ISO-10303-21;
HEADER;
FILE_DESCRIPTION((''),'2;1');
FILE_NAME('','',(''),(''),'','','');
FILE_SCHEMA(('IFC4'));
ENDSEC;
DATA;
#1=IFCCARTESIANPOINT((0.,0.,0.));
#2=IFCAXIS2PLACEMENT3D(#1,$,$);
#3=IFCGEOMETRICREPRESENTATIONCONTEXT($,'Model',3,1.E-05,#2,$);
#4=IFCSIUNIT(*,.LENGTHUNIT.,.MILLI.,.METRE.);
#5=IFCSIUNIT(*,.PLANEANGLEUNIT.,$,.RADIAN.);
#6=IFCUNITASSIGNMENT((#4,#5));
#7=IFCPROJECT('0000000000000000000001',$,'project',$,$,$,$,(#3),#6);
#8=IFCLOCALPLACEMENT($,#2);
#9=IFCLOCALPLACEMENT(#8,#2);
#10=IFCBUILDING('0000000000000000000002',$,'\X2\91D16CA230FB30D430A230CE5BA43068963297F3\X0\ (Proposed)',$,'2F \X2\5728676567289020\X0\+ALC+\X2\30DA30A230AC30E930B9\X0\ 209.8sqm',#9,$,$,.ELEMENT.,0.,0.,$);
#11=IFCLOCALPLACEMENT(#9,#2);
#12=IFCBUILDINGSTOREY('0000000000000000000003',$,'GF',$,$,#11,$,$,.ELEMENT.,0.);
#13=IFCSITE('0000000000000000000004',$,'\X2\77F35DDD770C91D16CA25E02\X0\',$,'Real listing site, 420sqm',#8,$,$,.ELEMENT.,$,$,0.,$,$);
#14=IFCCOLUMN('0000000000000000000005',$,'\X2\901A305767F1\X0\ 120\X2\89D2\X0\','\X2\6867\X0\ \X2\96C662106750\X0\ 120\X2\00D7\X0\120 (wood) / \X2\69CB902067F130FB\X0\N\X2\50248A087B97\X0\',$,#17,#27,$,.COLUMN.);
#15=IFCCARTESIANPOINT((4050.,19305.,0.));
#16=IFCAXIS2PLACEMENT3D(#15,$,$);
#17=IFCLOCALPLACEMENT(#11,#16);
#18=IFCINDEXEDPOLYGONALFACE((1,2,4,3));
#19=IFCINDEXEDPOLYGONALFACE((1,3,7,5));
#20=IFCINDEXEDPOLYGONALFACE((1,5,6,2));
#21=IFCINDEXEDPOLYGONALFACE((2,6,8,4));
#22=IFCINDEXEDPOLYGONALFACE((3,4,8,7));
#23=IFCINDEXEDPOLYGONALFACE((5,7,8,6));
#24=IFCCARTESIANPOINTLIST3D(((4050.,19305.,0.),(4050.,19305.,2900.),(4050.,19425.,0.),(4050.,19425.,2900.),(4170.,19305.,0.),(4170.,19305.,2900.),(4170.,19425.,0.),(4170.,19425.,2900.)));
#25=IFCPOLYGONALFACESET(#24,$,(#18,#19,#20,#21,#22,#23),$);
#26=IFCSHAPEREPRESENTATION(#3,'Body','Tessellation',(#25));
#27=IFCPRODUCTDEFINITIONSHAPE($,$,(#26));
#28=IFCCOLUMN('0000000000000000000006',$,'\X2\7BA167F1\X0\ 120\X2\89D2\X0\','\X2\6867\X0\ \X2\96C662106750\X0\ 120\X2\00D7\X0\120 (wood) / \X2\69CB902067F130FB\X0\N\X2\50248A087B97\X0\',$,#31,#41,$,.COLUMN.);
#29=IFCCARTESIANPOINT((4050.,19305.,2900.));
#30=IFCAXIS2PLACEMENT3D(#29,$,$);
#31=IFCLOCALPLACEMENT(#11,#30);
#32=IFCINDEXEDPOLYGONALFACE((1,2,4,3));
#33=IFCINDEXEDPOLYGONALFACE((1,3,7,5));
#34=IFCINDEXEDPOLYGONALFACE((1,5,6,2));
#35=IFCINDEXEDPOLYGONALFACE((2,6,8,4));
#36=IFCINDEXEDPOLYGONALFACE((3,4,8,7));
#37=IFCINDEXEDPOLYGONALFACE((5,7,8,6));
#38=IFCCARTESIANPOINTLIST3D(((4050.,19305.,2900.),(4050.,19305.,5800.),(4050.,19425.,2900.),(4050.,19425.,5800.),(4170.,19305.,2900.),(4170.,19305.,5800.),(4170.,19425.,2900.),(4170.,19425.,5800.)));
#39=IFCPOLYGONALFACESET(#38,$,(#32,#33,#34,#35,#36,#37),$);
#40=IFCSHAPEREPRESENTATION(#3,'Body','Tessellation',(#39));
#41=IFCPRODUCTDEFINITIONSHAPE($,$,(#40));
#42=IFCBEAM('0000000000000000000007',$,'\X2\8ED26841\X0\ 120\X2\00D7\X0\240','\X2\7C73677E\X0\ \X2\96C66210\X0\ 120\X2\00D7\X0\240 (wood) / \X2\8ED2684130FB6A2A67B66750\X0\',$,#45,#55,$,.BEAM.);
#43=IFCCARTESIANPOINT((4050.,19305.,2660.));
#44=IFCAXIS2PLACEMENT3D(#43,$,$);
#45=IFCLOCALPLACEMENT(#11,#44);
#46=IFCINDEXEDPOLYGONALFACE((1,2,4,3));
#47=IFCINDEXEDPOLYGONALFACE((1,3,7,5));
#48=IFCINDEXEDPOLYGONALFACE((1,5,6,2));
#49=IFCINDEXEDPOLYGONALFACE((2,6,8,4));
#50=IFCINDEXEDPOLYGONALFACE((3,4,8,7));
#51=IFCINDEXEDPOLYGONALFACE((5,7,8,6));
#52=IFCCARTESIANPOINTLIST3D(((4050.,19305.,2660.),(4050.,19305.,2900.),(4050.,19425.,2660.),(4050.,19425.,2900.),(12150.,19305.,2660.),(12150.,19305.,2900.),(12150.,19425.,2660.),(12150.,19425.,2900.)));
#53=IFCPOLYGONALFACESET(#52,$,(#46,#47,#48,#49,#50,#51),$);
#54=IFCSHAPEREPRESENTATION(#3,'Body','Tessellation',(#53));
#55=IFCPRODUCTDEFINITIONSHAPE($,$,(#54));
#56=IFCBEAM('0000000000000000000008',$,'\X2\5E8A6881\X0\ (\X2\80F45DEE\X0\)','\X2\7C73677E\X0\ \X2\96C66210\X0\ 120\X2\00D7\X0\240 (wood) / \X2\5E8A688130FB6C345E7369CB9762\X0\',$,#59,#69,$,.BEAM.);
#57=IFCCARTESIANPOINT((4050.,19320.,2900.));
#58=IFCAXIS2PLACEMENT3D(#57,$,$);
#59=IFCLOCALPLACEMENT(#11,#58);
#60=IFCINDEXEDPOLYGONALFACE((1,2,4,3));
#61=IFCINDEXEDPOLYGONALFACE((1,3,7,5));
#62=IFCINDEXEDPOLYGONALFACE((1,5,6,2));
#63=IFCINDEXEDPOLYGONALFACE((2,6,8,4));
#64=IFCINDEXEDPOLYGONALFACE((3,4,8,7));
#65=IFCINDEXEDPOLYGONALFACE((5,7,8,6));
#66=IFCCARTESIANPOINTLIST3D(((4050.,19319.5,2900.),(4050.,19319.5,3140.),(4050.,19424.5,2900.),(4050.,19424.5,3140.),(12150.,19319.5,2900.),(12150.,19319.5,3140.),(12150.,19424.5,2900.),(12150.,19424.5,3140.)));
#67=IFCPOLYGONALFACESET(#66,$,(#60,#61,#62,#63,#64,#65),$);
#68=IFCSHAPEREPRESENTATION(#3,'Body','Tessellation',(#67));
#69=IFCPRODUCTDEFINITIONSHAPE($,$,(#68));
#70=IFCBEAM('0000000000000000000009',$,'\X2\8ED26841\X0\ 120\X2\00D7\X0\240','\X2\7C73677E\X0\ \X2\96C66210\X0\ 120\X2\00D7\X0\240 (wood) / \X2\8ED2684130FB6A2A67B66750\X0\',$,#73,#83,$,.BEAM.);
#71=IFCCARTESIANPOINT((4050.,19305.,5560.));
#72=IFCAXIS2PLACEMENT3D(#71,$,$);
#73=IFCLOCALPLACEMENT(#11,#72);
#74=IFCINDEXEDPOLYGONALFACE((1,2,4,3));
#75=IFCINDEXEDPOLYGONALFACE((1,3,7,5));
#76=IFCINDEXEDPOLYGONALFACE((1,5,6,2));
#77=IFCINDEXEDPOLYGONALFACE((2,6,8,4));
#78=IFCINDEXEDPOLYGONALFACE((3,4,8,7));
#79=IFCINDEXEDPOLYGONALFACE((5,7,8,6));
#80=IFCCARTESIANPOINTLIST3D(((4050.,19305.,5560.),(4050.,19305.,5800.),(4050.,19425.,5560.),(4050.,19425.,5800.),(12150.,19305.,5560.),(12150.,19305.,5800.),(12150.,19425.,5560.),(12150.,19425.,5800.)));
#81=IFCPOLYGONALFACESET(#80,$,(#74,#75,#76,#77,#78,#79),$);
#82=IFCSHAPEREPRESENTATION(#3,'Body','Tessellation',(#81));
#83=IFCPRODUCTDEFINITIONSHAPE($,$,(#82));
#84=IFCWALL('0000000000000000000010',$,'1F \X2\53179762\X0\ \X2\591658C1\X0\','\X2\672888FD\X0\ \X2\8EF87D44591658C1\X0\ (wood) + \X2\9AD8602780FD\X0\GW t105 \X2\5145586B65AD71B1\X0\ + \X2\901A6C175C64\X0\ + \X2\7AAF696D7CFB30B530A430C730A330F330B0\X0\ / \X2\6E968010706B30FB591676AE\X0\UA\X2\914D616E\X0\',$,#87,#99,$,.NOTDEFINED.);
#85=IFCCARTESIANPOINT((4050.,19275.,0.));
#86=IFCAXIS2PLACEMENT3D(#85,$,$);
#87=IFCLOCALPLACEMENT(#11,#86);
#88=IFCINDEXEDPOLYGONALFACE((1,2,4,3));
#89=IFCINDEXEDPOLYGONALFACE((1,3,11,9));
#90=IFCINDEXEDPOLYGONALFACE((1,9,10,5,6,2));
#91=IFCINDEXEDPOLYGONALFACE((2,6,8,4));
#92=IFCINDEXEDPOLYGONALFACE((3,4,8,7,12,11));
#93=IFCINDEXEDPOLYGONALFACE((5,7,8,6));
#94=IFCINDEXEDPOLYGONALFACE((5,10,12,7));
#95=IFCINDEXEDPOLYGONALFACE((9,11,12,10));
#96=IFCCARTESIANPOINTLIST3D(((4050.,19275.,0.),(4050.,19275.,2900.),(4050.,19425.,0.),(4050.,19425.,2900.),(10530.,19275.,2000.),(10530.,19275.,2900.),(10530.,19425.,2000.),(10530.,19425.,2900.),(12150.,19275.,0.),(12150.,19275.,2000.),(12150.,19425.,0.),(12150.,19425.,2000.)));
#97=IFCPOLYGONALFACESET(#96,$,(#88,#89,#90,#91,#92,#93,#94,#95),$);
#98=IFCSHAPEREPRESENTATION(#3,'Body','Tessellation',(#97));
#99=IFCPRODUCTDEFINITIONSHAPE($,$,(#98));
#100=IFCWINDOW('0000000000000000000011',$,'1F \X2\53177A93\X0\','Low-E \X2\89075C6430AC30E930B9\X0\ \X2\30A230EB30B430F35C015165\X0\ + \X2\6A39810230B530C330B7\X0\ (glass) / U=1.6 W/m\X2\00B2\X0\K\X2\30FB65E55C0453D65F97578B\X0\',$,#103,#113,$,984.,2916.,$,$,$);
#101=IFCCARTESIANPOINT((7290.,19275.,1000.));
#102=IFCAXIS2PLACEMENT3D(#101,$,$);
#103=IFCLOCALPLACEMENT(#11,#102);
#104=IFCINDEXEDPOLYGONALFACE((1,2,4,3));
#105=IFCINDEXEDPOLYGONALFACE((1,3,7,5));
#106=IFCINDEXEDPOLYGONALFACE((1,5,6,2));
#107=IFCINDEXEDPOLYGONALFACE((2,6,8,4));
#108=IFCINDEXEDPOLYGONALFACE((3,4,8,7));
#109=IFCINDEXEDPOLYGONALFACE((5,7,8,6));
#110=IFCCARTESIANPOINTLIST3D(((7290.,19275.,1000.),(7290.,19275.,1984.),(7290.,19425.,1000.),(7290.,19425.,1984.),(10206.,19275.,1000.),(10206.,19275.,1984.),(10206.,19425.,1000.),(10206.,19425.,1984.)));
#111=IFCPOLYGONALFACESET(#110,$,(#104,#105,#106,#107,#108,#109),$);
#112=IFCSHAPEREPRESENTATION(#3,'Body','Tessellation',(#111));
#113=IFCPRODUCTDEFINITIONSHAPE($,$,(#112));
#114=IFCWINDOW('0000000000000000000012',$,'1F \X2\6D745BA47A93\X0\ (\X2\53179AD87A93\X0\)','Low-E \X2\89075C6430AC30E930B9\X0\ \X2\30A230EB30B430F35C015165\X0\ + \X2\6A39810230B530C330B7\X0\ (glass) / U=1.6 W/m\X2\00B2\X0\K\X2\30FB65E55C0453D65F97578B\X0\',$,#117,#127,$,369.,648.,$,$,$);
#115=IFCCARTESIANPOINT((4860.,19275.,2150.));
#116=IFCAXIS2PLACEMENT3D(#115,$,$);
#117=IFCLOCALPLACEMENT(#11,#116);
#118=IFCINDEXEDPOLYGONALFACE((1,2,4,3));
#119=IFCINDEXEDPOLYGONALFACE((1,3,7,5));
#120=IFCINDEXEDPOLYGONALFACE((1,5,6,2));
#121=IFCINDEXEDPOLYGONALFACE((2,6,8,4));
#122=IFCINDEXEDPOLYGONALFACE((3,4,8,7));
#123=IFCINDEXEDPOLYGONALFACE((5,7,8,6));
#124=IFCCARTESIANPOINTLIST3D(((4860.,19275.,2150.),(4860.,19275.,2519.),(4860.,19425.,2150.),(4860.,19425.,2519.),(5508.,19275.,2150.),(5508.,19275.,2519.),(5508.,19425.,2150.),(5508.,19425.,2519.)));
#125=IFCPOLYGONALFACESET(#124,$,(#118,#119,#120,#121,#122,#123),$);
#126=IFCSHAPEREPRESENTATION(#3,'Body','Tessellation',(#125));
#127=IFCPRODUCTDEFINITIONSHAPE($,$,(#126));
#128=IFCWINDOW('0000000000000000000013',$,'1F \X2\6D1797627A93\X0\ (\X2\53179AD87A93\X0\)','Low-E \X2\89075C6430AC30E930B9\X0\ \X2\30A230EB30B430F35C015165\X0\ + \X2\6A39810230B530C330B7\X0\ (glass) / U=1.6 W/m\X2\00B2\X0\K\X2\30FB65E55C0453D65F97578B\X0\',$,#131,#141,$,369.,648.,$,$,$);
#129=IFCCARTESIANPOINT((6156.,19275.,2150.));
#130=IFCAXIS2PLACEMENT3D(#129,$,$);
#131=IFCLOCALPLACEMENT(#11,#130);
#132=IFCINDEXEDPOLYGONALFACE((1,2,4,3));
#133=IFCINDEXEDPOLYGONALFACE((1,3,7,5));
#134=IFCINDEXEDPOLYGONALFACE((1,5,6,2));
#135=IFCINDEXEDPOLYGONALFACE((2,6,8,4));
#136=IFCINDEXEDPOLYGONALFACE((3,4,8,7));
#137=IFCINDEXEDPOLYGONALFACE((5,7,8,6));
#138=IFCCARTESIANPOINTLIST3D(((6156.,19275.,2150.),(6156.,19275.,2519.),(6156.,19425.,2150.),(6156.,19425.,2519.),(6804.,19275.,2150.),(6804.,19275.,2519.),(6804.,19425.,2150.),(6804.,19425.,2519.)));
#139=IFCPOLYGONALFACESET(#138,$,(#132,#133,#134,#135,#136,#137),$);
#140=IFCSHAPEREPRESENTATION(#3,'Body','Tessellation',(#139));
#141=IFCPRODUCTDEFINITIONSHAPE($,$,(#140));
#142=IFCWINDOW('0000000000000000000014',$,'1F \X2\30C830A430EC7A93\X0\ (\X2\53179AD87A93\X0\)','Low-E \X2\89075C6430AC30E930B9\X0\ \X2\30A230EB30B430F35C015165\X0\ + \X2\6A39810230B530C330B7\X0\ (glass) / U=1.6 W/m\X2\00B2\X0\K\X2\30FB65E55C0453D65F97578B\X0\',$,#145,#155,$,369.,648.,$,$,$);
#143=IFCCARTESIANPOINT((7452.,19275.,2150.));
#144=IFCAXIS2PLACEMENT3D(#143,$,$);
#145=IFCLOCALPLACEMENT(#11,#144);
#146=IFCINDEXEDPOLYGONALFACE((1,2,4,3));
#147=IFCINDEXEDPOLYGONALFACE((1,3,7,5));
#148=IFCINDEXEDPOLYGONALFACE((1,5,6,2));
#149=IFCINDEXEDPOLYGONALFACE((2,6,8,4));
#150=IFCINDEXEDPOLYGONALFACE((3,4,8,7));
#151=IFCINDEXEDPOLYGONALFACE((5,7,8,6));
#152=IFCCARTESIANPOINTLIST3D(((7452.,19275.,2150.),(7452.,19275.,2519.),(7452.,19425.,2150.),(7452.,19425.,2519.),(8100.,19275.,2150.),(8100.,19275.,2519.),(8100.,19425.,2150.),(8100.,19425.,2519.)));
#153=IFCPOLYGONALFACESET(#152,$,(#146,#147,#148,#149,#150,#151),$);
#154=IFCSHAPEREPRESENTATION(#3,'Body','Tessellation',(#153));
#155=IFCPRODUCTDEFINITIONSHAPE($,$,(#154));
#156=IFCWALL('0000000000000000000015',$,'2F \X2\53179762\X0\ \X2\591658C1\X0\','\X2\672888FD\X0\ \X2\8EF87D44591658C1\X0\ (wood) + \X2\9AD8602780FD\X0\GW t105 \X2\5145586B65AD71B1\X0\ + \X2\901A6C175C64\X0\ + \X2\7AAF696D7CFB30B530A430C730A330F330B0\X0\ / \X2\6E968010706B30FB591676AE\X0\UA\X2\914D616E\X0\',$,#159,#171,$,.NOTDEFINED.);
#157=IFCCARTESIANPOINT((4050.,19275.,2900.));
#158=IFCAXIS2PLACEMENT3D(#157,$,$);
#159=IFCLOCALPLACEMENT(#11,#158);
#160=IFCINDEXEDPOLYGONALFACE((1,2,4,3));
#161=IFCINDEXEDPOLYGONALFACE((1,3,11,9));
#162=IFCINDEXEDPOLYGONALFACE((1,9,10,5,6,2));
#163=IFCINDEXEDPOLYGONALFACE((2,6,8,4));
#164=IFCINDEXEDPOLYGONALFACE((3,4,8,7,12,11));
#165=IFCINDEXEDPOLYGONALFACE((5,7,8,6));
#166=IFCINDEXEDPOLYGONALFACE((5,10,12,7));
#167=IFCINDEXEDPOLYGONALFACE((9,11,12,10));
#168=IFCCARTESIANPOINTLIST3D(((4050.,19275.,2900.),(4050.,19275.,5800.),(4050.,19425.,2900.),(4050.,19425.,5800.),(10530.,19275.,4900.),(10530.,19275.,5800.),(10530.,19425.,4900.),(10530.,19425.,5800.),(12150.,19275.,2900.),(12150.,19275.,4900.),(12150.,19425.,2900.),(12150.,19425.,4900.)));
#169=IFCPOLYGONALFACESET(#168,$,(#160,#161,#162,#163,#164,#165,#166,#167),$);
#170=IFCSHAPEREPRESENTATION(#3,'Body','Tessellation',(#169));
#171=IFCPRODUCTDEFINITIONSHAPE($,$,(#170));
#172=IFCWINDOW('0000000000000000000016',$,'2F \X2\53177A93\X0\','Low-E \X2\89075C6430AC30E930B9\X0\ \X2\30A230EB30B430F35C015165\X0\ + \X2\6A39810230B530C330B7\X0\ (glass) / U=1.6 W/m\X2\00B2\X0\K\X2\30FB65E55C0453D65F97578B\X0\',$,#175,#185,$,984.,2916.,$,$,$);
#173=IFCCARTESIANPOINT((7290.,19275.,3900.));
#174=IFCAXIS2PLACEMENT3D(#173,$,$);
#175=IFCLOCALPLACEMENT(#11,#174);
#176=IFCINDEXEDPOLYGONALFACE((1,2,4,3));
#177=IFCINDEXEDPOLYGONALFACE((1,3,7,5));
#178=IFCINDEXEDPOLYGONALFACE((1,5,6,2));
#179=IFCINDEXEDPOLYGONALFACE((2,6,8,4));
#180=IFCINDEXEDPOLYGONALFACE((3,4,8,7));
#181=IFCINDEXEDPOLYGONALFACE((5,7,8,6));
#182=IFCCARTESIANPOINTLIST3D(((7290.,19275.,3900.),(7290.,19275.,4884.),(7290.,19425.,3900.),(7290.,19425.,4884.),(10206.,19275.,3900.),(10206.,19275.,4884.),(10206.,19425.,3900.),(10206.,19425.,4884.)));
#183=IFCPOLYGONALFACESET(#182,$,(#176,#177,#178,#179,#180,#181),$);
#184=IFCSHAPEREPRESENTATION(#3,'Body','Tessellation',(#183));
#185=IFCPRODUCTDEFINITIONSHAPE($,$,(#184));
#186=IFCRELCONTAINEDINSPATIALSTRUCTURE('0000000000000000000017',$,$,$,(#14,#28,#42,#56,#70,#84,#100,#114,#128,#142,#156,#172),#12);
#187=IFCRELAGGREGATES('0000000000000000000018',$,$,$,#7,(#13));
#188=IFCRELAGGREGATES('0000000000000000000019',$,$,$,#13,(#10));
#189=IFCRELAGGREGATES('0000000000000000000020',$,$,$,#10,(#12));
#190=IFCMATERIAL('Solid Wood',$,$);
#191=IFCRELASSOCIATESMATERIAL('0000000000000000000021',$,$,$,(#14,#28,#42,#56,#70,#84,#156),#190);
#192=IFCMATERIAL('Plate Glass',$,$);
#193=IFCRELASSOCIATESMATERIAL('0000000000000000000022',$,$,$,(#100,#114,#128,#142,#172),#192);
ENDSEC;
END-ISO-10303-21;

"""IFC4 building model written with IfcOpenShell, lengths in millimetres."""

from ifc_helpers import new_model, si_unit, frame, frame_2d, origin, place, context, project, spatial, rectangle, extrude, material, element, fill, save


model = new_model("IFC4")

# Units and contexts
model_context = context("Model", 3, precision=1e-05, world=origin())
ifc_project = project(units=[si_unit("LENGTHUNIT", "METRE", prefix="MILLI"), si_unit("PLANEANGLEUNIT", "RADIAN")], contexts=[model_context])

# Site, building, storey
site_placement = place(None, origin())
site = spatial("IfcSite", under=ifc_project, at=site_placement, Name="石川県金沢市", ObjectType="Real listing site, 420sqm", CompositionType="ELEMENT", RefElevation=0.0)
building_placement = place(site_placement, origin())
building = spatial("IfcBuilding", under=site, at=building_placement, Name="金沢・ピアノ室と防音 (Proposed)", ObjectType="2F 在来木造+ALC+ペアガラス 209.8sqm", CompositionType="ELEMENT", ElevationOfRefHeight=0.0, ElevationOfTerrain=0.0)
storey_placement = place(building_placement, origin())
storey = spatial("IfcBuildingStorey", under=building, at=storey_placement, Name="GF", CompositionType="ELEMENT", Elevation=0.0)

# Columns
ifc_material_1 = material(Name="Solid Wood")
column_1_placement = place(storey_placement, frame((4050.0, 19305.0, 0.0)))
element("IfcColumn", 1, at=column_1_placement, inside=storey, material=ifc_material_1, Name="通し柱 120角", Description="桧 集成材 120×120 (wood) / 構造柱・N値計算", PredefinedType="COLUMN", context=model_context, shape_type="SweptSolid", body=[
    extrude(rectangle(XDim=120.0, YDim=120.0, at=frame_2d((60.0, 60.0))), frame((4050.0, 19305.0, 0.0)), (0.0, 0.0, 1.0), 2900.0),
])
column_2_placement = place(storey_placement, frame((4050.0, 19305.0, 2900.0)))
element("IfcColumn", 2, at=column_2_placement, inside=storey, material=ifc_material_1, Name="管柱 120角", Description="桧 集成材 120×120 (wood) / 構造柱・N値計算", PredefinedType="COLUMN", context=model_context, shape_type="SweptSolid", body=[
    extrude(rectangle(XDim=120.0, YDim=120.0, at=frame_2d((60.0, 60.0))), frame((4050.0, 19305.0, 2900.0)), (0.0, 0.0, 1.0), 2900.0),
])

# Beams
beam_1_placement = place(storey_placement, frame((4050.0, 19305.0, 2660.0)))
element("IfcBeam", 3, at=beam_1_placement, inside=storey, material=ifc_material_1, Name="軒桁 120×240", Description="米松 集成 120×240 (wood) / 軒桁・横架材", PredefinedType="BEAM", context=model_context, shape_type="SweptSolid", body=[
    extrude(rectangle(XDim=8100.0, YDim=120.0, at=frame_2d((4050.0, 60.0))), frame((4050.0, 19305.0, 2660.0)), (0.0, 0.0, 1.0), 240.0),
])
beam_2_placement = place(storey_placement, frame((4050.0, 19320.0, 2900.0)))
element("IfcBeam", 4, at=beam_2_placement, inside=storey, material=ifc_material_1, Name="床梁 (胴差)", Description="米松 集成 120×240 (wood) / 床梁・水平構面", PredefinedType="BEAM", context=model_context, shape_type="SweptSolid", body=[
    extrude(rectangle(XDim=8100.0, YDim=105.0, at=frame_2d((4050.0, 52.0))), frame((4050.0, 19320.0, 2900.0)), (0.0, 0.0, 1.0), 240.0),
])
beam_3_placement = place(storey_placement, frame((4050.0, 19305.0, 5560.0)))
element("IfcBeam", 5, at=beam_3_placement, inside=storey, material=ifc_material_1, Name="軒桁 120×240", Description="米松 集成 120×240 (wood) / 軒桁・横架材", PredefinedType="BEAM", context=model_context, shape_type="SweptSolid", body=[
    extrude(rectangle(XDim=8100.0, YDim=120.0, at=frame_2d((4050.0, 60.0))), frame((4050.0, 19305.0, 5560.0)), (0.0, 0.0, 1.0), 240.0),
])

# Wall, openings, windows
wall_1_placement = place(storey_placement, frame((4050.0, 19275.0, 0.0)))
wall_1 = element("IfcWall", 6, at=wall_1_placement, inside=storey, material=ifc_material_1, Name="1F 北面 外壁", Description="木製 軸組外壁 (wood) + 高性能GW t105 充填断熱 + 通気層 + 窯業系サイディング / 準耐火・外皮UA配慮", PredefinedType="NOTDEFINED", context=model_context, shape_type="SweptSolid", body=[
    extrude(rectangle(XDim=8100.0, YDim=150.0, at=frame_2d((4050.0, 75.0))), frame((4050.0, 19275.0, 0.0)), (0.0, 0.0, 1.0), 2900.0),
])
opening_1_placement = place(storey_placement, frame((7290.0, 19275.0, 1000.0)))
opening_1 = element("IfcOpeningElement", 7, at=opening_1_placement, cuts=wall_1, PredefinedType="NOTDEFINED", context=model_context, shape_type="SweptSolid", body=[
    extrude(rectangle(XDim=2916.0, YDim=150.0, at=frame_2d((1458.0, 75.0))), frame((7290.0, 19275.0, 1000.0)), (0.0, 0.0, 1.0), 984.0),
])
opening_2_placement = place(storey_placement, frame((4860.0, 19275.0, 2150.0)))
opening_2 = element("IfcOpeningElement", 8, at=opening_2_placement, cuts=wall_1, PredefinedType="NOTDEFINED", context=model_context, shape_type="SweptSolid", body=[
    extrude(rectangle(XDim=648.0, YDim=150.0, at=frame_2d((324.0, 75.0))), frame((4860.0, 19275.0, 2150.0)), (0.0, 0.0, 1.0), 369.0),
])
opening_3_placement = place(storey_placement, frame((6156.0, 19275.0, 2150.0)))
opening_3 = element("IfcOpeningElement", 9, at=opening_3_placement, cuts=wall_1, PredefinedType="NOTDEFINED", context=model_context, shape_type="SweptSolid", body=[
    extrude(rectangle(XDim=648.0, YDim=150.0, at=frame_2d((324.0, 75.0))), frame((6156.0, 19275.0, 2150.0)), (0.0, 0.0, 1.0), 369.0),
])
opening_4_placement = place(storey_placement, frame((7452.0, 19275.0, 2150.0)))
opening_4 = element("IfcOpeningElement", 10, at=opening_4_placement, cuts=wall_1, PredefinedType="NOTDEFINED", context=model_context, shape_type="SweptSolid", body=[
    extrude(rectangle(XDim=648.0, YDim=150.0, at=frame_2d((324.0, 75.0))), frame((7452.0, 19275.0, 2150.0)), (0.0, 0.0, 1.0), 369.0),
])
ifc_material_2 = material(Name="Plate Glass")
window_1_placement = place(storey_placement, frame((7290.0, 19275.0, 1000.0)))
window_1 = element("IfcWindow", 11, at=window_1_placement, inside=storey, material=ifc_material_2, Name="1F 北窓", Description="Low-E 複層ガラス アルゴン封入 + 樹脂サッシ (glass) / U=1.6 W/m²K・日射取得型", OverallHeight=984.0, OverallWidth=2916.0, context=model_context, shape_type="SweptSolid", body=[
    extrude(rectangle(XDim=2916.0, YDim=150.0, at=frame_2d((1458.0, 75.0))), frame((7290.0, 19275.0, 1000.0)), (0.0, 0.0, 1.0), 984.0),
])
fill(opening_1, window_1)
window_2_placement = place(storey_placement, frame((4860.0, 19275.0, 2150.0)))
window_2 = element("IfcWindow", 12, at=window_2_placement, inside=storey, material=ifc_material_2, Name="1F 浴室窓 (北高窓)", Description="Low-E 複層ガラス アルゴン封入 + 樹脂サッシ (glass) / U=1.6 W/m²K・日射取得型", OverallHeight=369.0, OverallWidth=648.0, context=model_context, shape_type="SweptSolid", body=[
    extrude(rectangle(XDim=648.0, YDim=150.0, at=frame_2d((324.0, 75.0))), frame((4860.0, 19275.0, 2150.0)), (0.0, 0.0, 1.0), 369.0),
])
fill(opening_2, window_2)
window_3_placement = place(storey_placement, frame((6156.0, 19275.0, 2150.0)))
window_3 = element("IfcWindow", 13, at=window_3_placement, inside=storey, material=ifc_material_2, Name="1F 洗面窓 (北高窓)", Description="Low-E 複層ガラス アルゴン封入 + 樹脂サッシ (glass) / U=1.6 W/m²K・日射取得型", OverallHeight=369.0, OverallWidth=648.0, context=model_context, shape_type="SweptSolid", body=[
    extrude(rectangle(XDim=648.0, YDim=150.0, at=frame_2d((324.0, 75.0))), frame((6156.0, 19275.0, 2150.0)), (0.0, 0.0, 1.0), 369.0),
])
fill(opening_3, window_3)
window_4_placement = place(storey_placement, frame((7452.0, 19275.0, 2150.0)))
window_4 = element("IfcWindow", 14, at=window_4_placement, inside=storey, material=ifc_material_2, Name="1F トイレ窓 (北高窓)", Description="Low-E 複層ガラス アルゴン封入 + 樹脂サッシ (glass) / U=1.6 W/m²K・日射取得型", OverallHeight=369.0, OverallWidth=648.0, context=model_context, shape_type="SweptSolid", body=[
    extrude(rectangle(XDim=648.0, YDim=150.0, at=frame_2d((324.0, 75.0))), frame((7452.0, 19275.0, 2150.0)), (0.0, 0.0, 1.0), 369.0),
])
fill(opening_4, window_4)

# Wall, opening, window
wall_2_placement = place(storey_placement, frame((4050.0, 19275.0, 2900.0)))
wall_2 = element("IfcWall", 15, at=wall_2_placement, inside=storey, material=ifc_material_1, Name="2F 北面 外壁", Description="木製 軸組外壁 (wood) + 高性能GW t105 充填断熱 + 通気層 + 窯業系サイディング / 準耐火・外皮UA配慮", PredefinedType="NOTDEFINED", context=model_context, shape_type="SweptSolid", body=[
    extrude(rectangle(XDim=8100.0, YDim=150.0, at=frame_2d((4050.0, 75.0))), frame((4050.0, 19275.0, 2900.0)), (0.0, 0.0, 1.0), 2900.0),
])
opening_5_placement = place(storey_placement, frame((7290.0, 19275.0, 3900.0)))
opening_5 = element("IfcOpeningElement", 16, at=opening_5_placement, cuts=wall_2, PredefinedType="NOTDEFINED", context=model_context, shape_type="SweptSolid", body=[
    extrude(rectangle(XDim=2916.0, YDim=150.0, at=frame_2d((1458.0, 75.0))), frame((7290.0, 19275.0, 3900.0)), (0.0, 0.0, 1.0), 984.0),
])
window_5_placement = place(storey_placement, frame((7290.0, 19275.0, 3900.0)))
window_5 = element("IfcWindow", 17, at=window_5_placement, inside=storey, material=ifc_material_2, Name="2F 北窓", Description="Low-E 複層ガラス アルゴン封入 + 樹脂サッシ (glass) / U=1.6 W/m²K・日射取得型", OverallHeight=984.0, OverallWidth=2916.0, context=model_context, shape_type="SweptSolid", body=[
    extrude(rectangle(XDim=2916.0, YDim=150.0, at=frame_2d((1458.0, 75.0))), frame((7290.0, 19275.0, 3900.0)), (0.0, 0.0, 1.0), 984.0),
])
fill(opening_5, window_5)

save(model, "model.ifc")
